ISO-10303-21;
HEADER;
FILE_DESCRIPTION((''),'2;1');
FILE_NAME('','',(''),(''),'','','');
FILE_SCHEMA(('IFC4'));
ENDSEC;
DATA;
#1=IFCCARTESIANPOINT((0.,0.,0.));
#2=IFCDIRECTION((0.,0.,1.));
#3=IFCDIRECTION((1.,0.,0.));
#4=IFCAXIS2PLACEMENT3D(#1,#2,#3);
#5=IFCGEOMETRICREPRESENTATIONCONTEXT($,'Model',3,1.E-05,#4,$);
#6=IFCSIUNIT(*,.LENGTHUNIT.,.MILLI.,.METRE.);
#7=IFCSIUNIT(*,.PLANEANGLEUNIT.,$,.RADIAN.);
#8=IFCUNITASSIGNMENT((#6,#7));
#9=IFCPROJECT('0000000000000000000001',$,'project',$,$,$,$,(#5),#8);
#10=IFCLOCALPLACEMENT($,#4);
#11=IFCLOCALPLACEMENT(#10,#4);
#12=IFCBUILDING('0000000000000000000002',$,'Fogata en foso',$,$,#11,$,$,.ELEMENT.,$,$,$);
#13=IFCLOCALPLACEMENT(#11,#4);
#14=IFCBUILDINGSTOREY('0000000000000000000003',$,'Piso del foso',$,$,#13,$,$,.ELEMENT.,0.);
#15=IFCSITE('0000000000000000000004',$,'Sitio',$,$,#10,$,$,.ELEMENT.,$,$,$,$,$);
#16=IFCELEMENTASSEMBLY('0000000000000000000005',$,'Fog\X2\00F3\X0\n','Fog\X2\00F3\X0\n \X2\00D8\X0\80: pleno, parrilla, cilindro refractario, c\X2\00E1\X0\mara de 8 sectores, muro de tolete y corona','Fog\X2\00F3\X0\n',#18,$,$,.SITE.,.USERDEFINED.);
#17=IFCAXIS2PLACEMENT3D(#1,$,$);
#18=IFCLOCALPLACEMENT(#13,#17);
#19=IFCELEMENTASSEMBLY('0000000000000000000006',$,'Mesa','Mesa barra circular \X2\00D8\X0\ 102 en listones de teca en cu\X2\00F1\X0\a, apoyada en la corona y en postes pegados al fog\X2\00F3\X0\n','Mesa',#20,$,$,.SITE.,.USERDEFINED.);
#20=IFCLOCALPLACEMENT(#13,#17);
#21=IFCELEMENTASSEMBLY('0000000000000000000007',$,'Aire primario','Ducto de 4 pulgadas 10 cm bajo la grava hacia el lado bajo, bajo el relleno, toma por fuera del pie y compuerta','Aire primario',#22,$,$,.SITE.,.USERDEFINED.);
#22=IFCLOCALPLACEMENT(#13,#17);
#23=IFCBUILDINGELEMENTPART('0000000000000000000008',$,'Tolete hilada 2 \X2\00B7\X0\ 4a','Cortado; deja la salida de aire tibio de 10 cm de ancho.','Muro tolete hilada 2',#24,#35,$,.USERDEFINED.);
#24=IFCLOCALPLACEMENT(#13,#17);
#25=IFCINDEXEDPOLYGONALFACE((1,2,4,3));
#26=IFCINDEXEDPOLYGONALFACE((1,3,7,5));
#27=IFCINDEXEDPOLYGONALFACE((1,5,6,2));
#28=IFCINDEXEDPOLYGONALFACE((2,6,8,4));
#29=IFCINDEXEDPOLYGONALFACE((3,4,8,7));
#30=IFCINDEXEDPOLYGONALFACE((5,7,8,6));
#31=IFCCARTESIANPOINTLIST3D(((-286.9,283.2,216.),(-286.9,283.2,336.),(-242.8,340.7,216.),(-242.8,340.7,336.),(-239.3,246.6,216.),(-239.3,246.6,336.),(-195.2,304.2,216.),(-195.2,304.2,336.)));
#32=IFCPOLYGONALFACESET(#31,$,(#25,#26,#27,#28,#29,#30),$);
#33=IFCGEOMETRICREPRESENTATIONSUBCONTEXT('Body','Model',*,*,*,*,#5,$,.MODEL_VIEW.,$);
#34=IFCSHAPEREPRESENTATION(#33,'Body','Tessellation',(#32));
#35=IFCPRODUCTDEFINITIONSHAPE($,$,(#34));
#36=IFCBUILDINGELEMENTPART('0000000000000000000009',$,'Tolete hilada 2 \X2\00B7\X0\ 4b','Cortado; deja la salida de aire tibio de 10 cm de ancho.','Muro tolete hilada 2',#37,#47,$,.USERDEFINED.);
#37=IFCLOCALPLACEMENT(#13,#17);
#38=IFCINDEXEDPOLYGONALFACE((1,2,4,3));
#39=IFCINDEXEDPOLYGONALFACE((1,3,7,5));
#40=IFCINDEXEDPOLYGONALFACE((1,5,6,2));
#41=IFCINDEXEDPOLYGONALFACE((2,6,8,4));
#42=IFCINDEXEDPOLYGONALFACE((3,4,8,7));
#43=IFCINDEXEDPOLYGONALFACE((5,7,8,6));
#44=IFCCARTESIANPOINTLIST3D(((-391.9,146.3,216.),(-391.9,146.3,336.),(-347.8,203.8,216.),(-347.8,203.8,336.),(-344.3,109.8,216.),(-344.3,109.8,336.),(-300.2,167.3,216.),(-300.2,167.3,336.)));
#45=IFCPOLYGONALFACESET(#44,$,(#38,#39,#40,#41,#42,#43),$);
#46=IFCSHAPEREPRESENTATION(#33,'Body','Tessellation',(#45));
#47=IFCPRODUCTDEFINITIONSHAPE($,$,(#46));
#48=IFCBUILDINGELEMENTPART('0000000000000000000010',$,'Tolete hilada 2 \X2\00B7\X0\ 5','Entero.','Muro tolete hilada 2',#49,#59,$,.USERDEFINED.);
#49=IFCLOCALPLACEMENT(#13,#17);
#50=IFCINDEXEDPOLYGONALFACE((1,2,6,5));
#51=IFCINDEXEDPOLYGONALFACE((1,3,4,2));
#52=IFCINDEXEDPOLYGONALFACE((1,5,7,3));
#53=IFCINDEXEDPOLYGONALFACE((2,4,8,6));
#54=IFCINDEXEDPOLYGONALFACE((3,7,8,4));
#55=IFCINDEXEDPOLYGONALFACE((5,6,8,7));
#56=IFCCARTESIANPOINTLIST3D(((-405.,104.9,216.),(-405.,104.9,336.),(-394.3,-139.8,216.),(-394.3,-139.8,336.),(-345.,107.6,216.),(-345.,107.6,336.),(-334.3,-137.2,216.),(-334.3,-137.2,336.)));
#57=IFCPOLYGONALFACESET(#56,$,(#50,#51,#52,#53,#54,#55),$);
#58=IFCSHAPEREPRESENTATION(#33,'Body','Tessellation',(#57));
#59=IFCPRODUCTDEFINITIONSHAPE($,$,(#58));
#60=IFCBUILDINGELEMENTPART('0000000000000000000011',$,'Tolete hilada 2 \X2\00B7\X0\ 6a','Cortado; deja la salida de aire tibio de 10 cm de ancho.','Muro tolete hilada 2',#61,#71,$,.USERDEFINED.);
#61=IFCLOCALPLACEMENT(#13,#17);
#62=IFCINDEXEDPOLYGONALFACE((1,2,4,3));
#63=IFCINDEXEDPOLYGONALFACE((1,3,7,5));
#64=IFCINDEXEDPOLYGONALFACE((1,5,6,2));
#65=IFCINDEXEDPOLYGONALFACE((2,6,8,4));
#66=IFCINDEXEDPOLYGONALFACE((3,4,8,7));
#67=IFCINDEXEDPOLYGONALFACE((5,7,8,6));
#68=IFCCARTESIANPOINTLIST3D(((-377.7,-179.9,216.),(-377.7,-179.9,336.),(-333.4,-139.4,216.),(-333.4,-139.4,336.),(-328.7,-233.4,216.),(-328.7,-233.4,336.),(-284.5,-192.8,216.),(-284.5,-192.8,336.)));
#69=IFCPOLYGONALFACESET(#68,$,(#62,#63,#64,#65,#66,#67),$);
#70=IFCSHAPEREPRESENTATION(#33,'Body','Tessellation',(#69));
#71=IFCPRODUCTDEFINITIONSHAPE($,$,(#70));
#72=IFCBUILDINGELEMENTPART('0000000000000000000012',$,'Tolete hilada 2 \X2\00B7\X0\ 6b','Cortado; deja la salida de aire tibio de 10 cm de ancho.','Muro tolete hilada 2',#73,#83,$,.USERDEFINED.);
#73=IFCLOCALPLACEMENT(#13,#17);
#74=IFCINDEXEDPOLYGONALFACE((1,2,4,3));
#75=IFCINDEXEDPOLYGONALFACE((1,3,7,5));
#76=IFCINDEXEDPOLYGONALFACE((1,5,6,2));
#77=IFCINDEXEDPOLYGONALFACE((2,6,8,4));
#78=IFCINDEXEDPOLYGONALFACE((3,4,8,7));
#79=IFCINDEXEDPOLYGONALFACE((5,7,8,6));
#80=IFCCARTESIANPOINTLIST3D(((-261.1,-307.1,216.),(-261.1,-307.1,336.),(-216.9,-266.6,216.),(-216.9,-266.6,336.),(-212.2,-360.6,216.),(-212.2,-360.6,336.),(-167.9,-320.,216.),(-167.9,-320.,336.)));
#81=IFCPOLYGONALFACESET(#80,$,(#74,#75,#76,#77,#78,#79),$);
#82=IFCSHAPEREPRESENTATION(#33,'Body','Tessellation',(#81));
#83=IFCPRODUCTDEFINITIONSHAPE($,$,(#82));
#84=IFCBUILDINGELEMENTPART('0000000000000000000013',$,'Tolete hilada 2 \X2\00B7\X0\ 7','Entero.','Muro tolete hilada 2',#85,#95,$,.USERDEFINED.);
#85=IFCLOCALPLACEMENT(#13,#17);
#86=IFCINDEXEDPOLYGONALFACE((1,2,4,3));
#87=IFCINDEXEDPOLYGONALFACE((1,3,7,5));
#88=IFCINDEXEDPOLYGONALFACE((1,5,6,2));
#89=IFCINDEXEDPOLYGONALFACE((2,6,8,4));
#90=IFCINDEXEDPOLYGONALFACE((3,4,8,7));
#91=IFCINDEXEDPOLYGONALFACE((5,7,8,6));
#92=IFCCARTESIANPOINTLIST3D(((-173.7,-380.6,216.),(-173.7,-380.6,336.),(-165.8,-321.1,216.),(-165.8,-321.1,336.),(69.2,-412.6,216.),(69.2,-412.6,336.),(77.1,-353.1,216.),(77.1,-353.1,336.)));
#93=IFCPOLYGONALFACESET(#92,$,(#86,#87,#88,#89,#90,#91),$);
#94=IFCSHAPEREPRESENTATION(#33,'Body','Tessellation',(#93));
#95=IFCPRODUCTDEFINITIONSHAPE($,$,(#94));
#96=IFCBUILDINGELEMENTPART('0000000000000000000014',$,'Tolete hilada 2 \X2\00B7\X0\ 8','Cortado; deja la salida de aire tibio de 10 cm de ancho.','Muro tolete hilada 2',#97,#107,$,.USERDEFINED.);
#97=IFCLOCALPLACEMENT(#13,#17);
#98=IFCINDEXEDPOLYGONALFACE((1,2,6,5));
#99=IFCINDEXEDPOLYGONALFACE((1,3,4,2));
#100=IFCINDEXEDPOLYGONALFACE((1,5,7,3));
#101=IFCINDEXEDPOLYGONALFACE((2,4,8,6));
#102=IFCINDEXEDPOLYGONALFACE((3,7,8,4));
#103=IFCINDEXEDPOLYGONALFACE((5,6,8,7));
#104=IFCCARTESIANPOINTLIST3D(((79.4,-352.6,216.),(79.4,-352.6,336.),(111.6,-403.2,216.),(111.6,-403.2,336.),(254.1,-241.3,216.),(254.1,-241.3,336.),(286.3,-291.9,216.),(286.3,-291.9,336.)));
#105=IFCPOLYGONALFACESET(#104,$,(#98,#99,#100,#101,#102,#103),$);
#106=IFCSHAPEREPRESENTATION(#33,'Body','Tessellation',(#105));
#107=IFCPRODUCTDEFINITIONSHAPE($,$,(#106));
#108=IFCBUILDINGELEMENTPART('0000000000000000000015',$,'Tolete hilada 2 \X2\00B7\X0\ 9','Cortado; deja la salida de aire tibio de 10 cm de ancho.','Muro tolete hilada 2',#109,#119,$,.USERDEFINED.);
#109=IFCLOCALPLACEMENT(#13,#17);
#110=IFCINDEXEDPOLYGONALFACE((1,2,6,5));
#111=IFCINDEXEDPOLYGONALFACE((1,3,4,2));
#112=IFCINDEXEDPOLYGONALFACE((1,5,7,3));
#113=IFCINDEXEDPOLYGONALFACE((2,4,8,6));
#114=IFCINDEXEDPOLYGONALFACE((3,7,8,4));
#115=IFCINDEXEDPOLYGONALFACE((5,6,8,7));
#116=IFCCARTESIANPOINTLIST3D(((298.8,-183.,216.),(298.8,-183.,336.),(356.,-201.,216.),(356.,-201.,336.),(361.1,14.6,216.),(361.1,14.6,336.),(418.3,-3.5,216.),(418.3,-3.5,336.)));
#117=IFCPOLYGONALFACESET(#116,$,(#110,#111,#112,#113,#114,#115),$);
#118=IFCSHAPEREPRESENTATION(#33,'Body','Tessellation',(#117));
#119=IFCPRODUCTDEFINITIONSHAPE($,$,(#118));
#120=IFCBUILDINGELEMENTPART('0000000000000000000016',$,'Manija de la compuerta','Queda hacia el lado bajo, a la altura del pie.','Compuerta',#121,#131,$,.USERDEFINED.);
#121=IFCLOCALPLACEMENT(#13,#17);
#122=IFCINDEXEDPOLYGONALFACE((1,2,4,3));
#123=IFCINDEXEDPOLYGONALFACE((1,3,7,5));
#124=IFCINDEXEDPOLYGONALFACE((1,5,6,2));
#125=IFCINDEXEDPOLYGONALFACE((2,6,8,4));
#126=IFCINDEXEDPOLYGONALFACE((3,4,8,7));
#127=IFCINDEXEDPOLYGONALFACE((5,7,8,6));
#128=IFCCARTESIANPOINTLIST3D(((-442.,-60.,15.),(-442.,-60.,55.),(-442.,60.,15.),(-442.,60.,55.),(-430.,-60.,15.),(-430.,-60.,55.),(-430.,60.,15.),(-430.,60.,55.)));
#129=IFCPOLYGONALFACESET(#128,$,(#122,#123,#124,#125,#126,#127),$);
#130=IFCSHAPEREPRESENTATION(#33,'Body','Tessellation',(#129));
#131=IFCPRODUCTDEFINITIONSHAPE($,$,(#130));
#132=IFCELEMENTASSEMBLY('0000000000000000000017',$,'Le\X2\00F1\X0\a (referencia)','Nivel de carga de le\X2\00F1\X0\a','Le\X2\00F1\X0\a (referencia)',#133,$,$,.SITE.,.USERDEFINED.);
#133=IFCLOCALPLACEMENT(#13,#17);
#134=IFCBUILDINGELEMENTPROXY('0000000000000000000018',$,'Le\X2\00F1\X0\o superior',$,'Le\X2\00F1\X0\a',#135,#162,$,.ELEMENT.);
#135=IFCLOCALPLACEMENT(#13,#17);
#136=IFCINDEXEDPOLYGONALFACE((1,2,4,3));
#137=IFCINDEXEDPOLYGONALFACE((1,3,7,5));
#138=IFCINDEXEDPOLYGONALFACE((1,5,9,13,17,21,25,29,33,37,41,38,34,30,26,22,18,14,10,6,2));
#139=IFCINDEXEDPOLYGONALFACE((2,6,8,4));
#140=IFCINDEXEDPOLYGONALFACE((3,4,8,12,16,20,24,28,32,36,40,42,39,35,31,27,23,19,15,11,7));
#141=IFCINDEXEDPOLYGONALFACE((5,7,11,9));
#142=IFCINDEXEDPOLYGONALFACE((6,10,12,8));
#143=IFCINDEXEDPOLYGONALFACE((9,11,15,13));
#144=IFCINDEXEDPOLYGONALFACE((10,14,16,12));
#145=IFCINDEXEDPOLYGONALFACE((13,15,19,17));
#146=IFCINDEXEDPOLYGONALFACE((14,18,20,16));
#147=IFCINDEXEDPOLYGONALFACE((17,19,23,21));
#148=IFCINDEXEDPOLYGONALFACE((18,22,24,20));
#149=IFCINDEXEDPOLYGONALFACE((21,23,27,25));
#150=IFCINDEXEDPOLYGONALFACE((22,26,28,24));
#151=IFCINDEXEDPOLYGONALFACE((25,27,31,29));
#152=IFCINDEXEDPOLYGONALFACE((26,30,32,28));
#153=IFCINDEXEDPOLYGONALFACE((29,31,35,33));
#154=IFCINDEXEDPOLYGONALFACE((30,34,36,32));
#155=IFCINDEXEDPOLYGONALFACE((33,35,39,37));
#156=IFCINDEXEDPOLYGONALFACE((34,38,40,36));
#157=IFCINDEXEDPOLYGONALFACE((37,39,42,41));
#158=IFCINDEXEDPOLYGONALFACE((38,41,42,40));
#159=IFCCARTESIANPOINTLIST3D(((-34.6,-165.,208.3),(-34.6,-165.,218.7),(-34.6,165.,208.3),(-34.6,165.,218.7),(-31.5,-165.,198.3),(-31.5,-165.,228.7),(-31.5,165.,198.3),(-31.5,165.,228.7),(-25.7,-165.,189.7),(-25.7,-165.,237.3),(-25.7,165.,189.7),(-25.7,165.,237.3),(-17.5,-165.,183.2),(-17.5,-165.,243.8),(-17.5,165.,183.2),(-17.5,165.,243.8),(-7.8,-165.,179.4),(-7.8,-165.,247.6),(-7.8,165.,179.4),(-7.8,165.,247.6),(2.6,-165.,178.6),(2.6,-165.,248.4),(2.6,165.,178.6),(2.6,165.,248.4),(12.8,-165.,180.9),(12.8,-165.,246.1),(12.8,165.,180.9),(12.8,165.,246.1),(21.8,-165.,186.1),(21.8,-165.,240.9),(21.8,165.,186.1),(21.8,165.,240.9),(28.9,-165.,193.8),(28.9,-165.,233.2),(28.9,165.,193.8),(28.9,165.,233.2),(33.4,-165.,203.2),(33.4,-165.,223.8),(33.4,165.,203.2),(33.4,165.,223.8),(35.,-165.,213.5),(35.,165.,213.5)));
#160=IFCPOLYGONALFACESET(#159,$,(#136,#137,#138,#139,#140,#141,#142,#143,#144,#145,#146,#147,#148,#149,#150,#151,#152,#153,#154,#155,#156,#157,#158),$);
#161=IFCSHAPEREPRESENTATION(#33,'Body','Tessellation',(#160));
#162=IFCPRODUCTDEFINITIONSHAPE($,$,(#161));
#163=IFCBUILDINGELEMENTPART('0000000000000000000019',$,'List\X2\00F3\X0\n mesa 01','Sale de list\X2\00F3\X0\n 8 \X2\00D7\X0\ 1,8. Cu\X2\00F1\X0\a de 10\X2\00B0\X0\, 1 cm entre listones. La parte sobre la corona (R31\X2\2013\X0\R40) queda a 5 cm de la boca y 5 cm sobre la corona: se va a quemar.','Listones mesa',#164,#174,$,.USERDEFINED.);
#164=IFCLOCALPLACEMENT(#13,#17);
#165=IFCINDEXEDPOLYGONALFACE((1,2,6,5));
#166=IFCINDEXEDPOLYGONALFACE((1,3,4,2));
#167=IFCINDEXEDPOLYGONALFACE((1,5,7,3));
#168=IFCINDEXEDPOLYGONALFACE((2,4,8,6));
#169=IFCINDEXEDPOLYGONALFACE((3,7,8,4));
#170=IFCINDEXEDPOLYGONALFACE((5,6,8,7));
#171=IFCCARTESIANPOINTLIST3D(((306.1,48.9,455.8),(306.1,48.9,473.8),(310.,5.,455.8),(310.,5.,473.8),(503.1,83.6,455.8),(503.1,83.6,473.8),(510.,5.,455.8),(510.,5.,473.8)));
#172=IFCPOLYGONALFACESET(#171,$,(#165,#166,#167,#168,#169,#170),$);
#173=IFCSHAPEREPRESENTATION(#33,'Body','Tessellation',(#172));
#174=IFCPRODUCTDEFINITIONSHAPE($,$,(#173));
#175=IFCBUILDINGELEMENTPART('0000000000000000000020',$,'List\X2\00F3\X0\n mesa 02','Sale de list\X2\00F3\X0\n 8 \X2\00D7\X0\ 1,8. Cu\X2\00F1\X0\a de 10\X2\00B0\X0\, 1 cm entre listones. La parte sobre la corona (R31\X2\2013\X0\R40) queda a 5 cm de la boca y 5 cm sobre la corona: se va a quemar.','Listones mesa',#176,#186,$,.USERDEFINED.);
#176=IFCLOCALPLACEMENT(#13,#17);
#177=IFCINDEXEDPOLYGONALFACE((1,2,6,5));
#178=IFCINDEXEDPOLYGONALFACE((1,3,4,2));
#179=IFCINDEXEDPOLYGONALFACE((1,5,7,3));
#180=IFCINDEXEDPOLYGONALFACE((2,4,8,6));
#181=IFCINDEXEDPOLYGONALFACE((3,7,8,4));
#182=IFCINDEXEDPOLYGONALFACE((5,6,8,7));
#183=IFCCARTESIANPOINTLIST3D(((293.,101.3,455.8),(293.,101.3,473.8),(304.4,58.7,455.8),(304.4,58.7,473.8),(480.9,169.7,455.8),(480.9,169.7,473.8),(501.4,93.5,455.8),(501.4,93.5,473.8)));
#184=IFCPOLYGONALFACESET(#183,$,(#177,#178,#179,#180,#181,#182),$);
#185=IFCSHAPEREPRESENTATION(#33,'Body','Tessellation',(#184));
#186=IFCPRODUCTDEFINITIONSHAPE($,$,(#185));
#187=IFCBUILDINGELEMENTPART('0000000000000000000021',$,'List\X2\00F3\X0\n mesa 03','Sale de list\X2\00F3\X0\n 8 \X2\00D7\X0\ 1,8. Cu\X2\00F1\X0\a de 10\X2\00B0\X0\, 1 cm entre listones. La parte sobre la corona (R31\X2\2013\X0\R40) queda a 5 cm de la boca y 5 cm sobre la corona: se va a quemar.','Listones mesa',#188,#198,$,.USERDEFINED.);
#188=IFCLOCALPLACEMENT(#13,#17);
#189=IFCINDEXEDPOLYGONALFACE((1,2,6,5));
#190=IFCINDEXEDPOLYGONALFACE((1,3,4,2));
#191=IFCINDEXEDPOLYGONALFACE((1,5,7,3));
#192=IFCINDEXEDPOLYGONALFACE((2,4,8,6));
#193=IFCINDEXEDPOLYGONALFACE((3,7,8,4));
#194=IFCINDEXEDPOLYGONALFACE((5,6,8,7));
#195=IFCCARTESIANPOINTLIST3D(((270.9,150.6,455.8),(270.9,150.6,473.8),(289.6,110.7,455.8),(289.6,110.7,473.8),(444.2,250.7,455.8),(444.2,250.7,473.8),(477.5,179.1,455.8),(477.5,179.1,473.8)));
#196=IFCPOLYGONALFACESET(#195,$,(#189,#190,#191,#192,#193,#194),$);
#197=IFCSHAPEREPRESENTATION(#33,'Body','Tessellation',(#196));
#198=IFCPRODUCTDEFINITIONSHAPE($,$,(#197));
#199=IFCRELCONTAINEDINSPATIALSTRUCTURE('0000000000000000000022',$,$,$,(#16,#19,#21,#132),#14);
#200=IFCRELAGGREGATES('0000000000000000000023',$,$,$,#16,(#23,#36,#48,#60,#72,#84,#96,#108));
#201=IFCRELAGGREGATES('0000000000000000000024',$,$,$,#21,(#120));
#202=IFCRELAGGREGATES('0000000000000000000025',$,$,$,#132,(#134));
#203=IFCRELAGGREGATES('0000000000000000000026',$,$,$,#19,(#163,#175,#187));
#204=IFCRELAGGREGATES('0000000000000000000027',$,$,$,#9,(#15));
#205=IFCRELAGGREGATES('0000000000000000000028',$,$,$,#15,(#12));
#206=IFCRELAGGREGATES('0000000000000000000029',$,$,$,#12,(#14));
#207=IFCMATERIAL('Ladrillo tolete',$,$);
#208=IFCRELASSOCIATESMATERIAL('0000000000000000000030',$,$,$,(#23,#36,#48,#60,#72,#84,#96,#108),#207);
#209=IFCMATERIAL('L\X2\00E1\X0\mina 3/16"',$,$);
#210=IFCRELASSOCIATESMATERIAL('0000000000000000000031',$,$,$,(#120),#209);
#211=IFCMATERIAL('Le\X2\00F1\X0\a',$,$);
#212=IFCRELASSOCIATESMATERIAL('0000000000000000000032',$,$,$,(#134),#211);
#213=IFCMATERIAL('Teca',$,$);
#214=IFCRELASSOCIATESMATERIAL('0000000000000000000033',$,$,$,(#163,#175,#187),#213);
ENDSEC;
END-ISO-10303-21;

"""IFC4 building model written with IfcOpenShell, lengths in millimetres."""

from ifc_helpers import new_model, si_unit, frame, origin_with_axes, origin_2d, place, context, subcontext, project, spatial, polyline, circle, outline, extrude, material, element, aggregate, save


model = new_model("IFC4")

# Units and contexts
model_context = context("Model", 3, precision=1e-05, world=origin_with_axes())
body_context = subcontext(model_context, "Body", "Model", "MODEL_VIEW")
ifc_project = project(units=[si_unit("LENGTHUNIT", "METRE", prefix="MILLI"), si_unit("PLANEANGLEUNIT", "RADIAN")], contexts=[model_context])

# Site, building, storey
site_placement = place(None, origin_with_axes())
site = spatial("IfcSite", under=ifc_project, at=site_placement, Name="Sitio", CompositionType="ELEMENT")
building_placement = place(site_placement, origin_with_axes())
building = spatial("IfcBuilding", under=site, at=building_placement, Name="Fogata en foso", CompositionType="ELEMENT")
storey_placement = place(building_placement, origin_with_axes())
storey = spatial("IfcBuildingStorey", under=building, at=storey_placement, Name="Piso del foso", CompositionType="ELEMENT", Elevation=0.0)

# Element assembly
assembly_1_placement = place(storey_placement, origin_with_axes())
assembly_1 = element("IfcElementAssembly", 1, at=assembly_1_placement, inside=storey, Name="Fogón", Description="Fogón Ø80: pleno, parrilla, cilindro refractario, cámara de 8 sectores, muro de tolete y corona", ObjectType="Fogón", AssemblyPlace="SITE", PredefinedType="USERDEFINED")

# Element assembly
assembly_2_placement = place(storey_placement, origin_with_axes())
assembly_2 = element("IfcElementAssembly", 2, at=assembly_2_placement, inside=storey, Name="Mesa", Description="Mesa barra circular Ø 102 en listones de teca en cuña, apoyada en la corona y en postes pegados al fogón", ObjectType="Mesa", AssemblyPlace="SITE", PredefinedType="USERDEFINED")

# Element assembly
assembly_3_placement = place(storey_placement, origin_with_axes())
assembly_3 = element("IfcElementAssembly", 3, at=assembly_3_placement, inside=storey, Name="Aire primario", Description="Ducto de 4 pulgadas 10 cm bajo la grava hacia el lado bajo, bajo el relleno, toma por fuera del pie y compuerta", ObjectType="Aire primario", AssemblyPlace="SITE", PredefinedType="USERDEFINED")
ifc_material_1 = material(Name="Lámina 3/16\"")

# Building element parts
ifc_material_2 = material(Name="Ladrillo tolete")
building_element_part_1_placement = place(storey_placement, frame((0.0, 0.0, 216.0), z_axis=(0.0, 0.0, 1.0), x_axis=(1.0, 0.0, 0.0)))
building_element_part_1 = element("IfcBuildingElementPart", 4, at=building_element_part_1_placement, material=ifc_material_2, Name="Tolete hilada 2 · 4a", Description="Cortado; deja la salida de aire tibio de 10 cm de ancho.", ObjectType="Muro tolete hilada 2", PredefinedType="USERDEFINED", context=body_context, shape_type="SweptSolid", body=[
    extrude(outline(polyline([(-242.8, 340.7), (-286.9, 283.2), (-239.3, 246.6), (-195.2, 304.2), (-242.8, 340.7)])), origin_with_axes(), (0.0, 0.0, 1.0), 120.0),
])
building_element_part_2_placement = place(storey_placement, frame((0.0, 0.0, 216.0), z_axis=(0.0, 0.0, 1.0), x_axis=(1.0, 0.0, 0.0)))
building_element_part_2 = element("IfcBuildingElementPart", 5, at=building_element_part_2_placement, material=ifc_material_2, Name="Tolete hilada 2 · 4b", Description="Cortado; deja la salida de aire tibio de 10 cm de ancho.", ObjectType="Muro tolete hilada 2", PredefinedType="USERDEFINED", context=body_context, shape_type="SweptSolid", body=[
    extrude(outline(polyline([(-347.8, 203.8), (-391.9, 146.3), (-344.3, 109.8), (-300.2, 167.3), (-347.8, 203.8)])), origin_with_axes(), (0.0, 0.0, 1.0), 120.0),
])
building_element_part_3_placement = place(storey_placement, frame((0.0, 0.0, 216.0), z_axis=(0.0, 0.0, 1.0), x_axis=(1.0, 0.0, 0.0)))
building_element_part_3 = element("IfcBuildingElementPart", 6, at=building_element_part_3_placement, material=ifc_material_2, Name="Tolete hilada 2 · 5", Description="Entero.", ObjectType="Muro tolete hilada 2", PredefinedType="USERDEFINED", context=body_context, shape_type="SweptSolid", body=[
    extrude(outline(polyline([(-405.0, 104.9), (-394.3, -139.8), (-334.3, -137.2), (-345.0, 107.6), (-405.0, 104.9)])), origin_with_axes(), (0.0, 0.0, 1.0), 120.0),
])
building_element_part_4_placement = place(storey_placement, frame((0.0, 0.0, 216.0), z_axis=(0.0, 0.0, 1.0), x_axis=(1.0, 0.0, 0.0)))
building_element_part_4 = element("IfcBuildingElementPart", 7, at=building_element_part_4_placement, material=ifc_material_2, Name="Tolete hilada 2 · 6a", Description="Cortado; deja la salida de aire tibio de 10 cm de ancho.", ObjectType="Muro tolete hilada 2", PredefinedType="USERDEFINED", context=body_context, shape_type="SweptSolid", body=[
    extrude(outline(polyline([(-377.7, -179.9), (-328.7, -233.4), (-284.5, -192.8), (-333.4, -139.4), (-377.7, -179.9)])), origin_with_axes(), (0.0, 0.0, 1.0), 120.0),
])
building_element_part_5_placement = place(storey_placement, frame((0.0, 0.0, 216.0), z_axis=(0.0, 0.0, 1.0), x_axis=(1.0, 0.0, 0.0)))
building_element_part_5 = element("IfcBuildingElementPart", 8, at=building_element_part_5_placement, material=ifc_material_2, Name="Tolete hilada 2 · 6b", Description="Cortado; deja la salida de aire tibio de 10 cm de ancho.", ObjectType="Muro tolete hilada 2", PredefinedType="USERDEFINED", context=body_context, shape_type="SweptSolid", body=[
    extrude(outline(polyline([(-261.1, -307.1), (-212.2, -360.6), (-167.9, -320.0), (-216.9, -266.6), (-261.1, -307.1)])), origin_with_axes(), (0.0, 0.0, 1.0), 120.0),
])
building_element_part_6_placement = place(storey_placement, frame((0.0, 0.0, 216.0), z_axis=(0.0, 0.0, 1.0), x_axis=(1.0, 0.0, 0.0)))
building_element_part_6 = element("IfcBuildingElementPart", 9, at=building_element_part_6_placement, material=ifc_material_2, Name="Tolete hilada 2 · 7", Description="Entero.", ObjectType="Muro tolete hilada 2", PredefinedType="USERDEFINED", context=body_context, shape_type="SweptSolid", body=[
    extrude(outline(polyline([(-173.7, -380.6), (69.2, -412.6), (77.1, -353.1), (-165.8, -321.1), (-173.7, -380.6)])), origin_with_axes(), (0.0, 0.0, 1.0), 120.0),
])
building_element_part_7_placement = place(storey_placement, frame((0.0, 0.0, 216.0), z_axis=(0.0, 0.0, 1.0), x_axis=(1.0, 0.0, 0.0)))
building_element_part_7 = element("IfcBuildingElementPart", 10, at=building_element_part_7_placement, material=ifc_material_2, Name="Tolete hilada 2 · 8", Description="Cortado; deja la salida de aire tibio de 10 cm de ancho.", ObjectType="Muro tolete hilada 2", PredefinedType="USERDEFINED", context=body_context, shape_type="SweptSolid", body=[
    extrude(outline(polyline([(111.6, -403.2), (286.3, -291.9), (254.1, -241.3), (79.4, -352.6), (111.6, -403.2)])), origin_with_axes(), (0.0, 0.0, 1.0), 120.0),
])
building_element_part_8_placement = place(storey_placement, frame((0.0, 0.0, 216.0), z_axis=(0.0, 0.0, 1.0), x_axis=(1.0, 0.0, 0.0)))
building_element_part_8 = element("IfcBuildingElementPart", 11, at=building_element_part_8_placement, material=ifc_material_2, Name="Tolete hilada 2 · 9", Description="Cortado; deja la salida de aire tibio de 10 cm de ancho.", ObjectType="Muro tolete hilada 2", PredefinedType="USERDEFINED", context=body_context, shape_type="SweptSolid", body=[
    extrude(outline(polyline([(356.0, -201.0), (418.3, -3.5), (361.1, 14.6), (298.8, -183.0), (356.0, -201.0)])), origin_with_axes(), (0.0, 0.0, 1.0), 120.0),
])
aggregate(assembly_1, [building_element_part_1, building_element_part_2, building_element_part_3, building_element_part_4, building_element_part_5, building_element_part_6, building_element_part_7, building_element_part_8])
building_element_part_9_placement = place(storey_placement, frame((0.0, 0.0, 15.0), z_axis=(0.0, 0.0, 1.0), x_axis=(1.0, 0.0, 0.0)))
building_element_part_9 = element("IfcBuildingElementPart", 12, at=building_element_part_9_placement, material=ifc_material_1, Name="Manija de la compuerta", Description="Queda hacia el lado bajo, a la altura del pie.", ObjectType="Compuerta", PredefinedType="USERDEFINED", context=body_context, shape_type="SweptSolid", body=[
    extrude(outline(polyline([(-442.0, -60.0), (-430.0, -60.0), (-430.0, 60.0), (-442.0, 60.0), (-442.0, -60.0)])), origin_with_axes(), (0.0, 0.0, 1.0), 40.0),
])
aggregate(assembly_3, [building_element_part_9])

# Element assembly, building element proxy
assembly_4_placement = place(storey_placement, origin_with_axes())
assembly_4 = element("IfcElementAssembly", 13, at=assembly_4_placement, inside=storey, Name="Leña (referencia)", Description="Nivel de carga de leña", ObjectType="Leña (referencia)", AssemblyPlace="SITE", PredefinedType="USERDEFINED")
ifc_material_3 = material(Name="Leña")
proxy_placement = place(storey_placement, frame((0.0, -165.0, 213.5), z_axis=(0.0, 1.0, 0.0), x_axis=(1.0, 0.0, 0.0)))
proxy = element("IfcBuildingElementProxy", 14, at=proxy_placement, material=ifc_material_3, Name="Leño superior", ObjectType="Leña", PredefinedType="ELEMENT", context=body_context, shape_type="SweptSolid", body=[
    extrude(circle(Radius=35.0, at=origin_2d()), origin_with_axes(), (0.0, 0.0, 1.0), 330.0),
])
aggregate(assembly_4, [proxy])

# Building element parts
ifc_material_4 = material(Name="Teca")
building_element_part_10_placement = place(storey_placement, frame((0.0, 0.0, 455.8), z_axis=(0.0, 0.0, 1.0), x_axis=(1.0, 0.0, 0.0)))
building_element_part_10 = element("IfcBuildingElementPart", 15, at=building_element_part_10_placement, material=ifc_material_4, Name="Listón mesa 01", Description="Sale de listón 8 × 1,8. Cuña de 10°, 1 cm entre listones. La parte sobre la corona (R31–R40) queda a 5 cm de la boca y 5 cm sobre la corona: se va a quemar.", ObjectType="Listones mesa", PredefinedType="USERDEFINED", context=body_context, shape_type="SweptSolid", body=[
    extrude(outline(polyline([(310.0, 5.0), (510.0, 5.0), (503.1, 83.6), (306.1, 48.9), (310.0, 5.0)])), origin_with_axes(), (0.0, 0.0, 1.0), 18.0),
])
building_element_part_11_placement = place(storey_placement, frame((0.0, 0.0, 455.8), z_axis=(0.0, 0.0, 1.0), x_axis=(1.0, 0.0, 0.0)))
building_element_part_11 = element("IfcBuildingElementPart", 16, at=building_element_part_11_placement, material=ifc_material_4, Name="Listón mesa 02", Description="Sale de listón 8 × 1,8. Cuña de 10°, 1 cm entre listones. La parte sobre la corona (R31–R40) queda a 5 cm de la boca y 5 cm sobre la corona: se va a quemar.", ObjectType="Listones mesa", PredefinedType="USERDEFINED", context=body_context, shape_type="SweptSolid", body=[
    extrude(outline(polyline([(304.4, 58.7), (501.4, 93.5), (480.9, 169.7), (293.0, 101.3), (304.4, 58.7)])), origin_with_axes(), (0.0, 0.0, 1.0), 18.0),
])
building_element_part_12_placement = place(storey_placement, frame((0.0, 0.0, 455.8), z_axis=(0.0, 0.0, 1.0), x_axis=(1.0, 0.0, 0.0)))
building_element_part_12 = element("IfcBuildingElementPart", 17, at=building_element_part_12_placement, material=ifc_material_4, Name="Listón mesa 03", Description="Sale de listón 8 × 1,8. Cuña de 10°, 1 cm entre listones. La parte sobre la corona (R31–R40) queda a 5 cm de la boca y 5 cm sobre la corona: se va a quemar.", ObjectType="Listones mesa", PredefinedType="USERDEFINED", context=body_context, shape_type="SweptSolid", body=[
    extrude(outline(polyline([(289.6, 110.7), (477.5, 179.1), (444.2, 250.7), (270.9, 150.7), (289.6, 110.7)])), origin_with_axes(), (0.0, 0.0, 1.0), 18.0),
])
aggregate(assembly_2, [building_element_part_10, building_element_part_11, building_element_part_12])

save(model, "model.ifc")
